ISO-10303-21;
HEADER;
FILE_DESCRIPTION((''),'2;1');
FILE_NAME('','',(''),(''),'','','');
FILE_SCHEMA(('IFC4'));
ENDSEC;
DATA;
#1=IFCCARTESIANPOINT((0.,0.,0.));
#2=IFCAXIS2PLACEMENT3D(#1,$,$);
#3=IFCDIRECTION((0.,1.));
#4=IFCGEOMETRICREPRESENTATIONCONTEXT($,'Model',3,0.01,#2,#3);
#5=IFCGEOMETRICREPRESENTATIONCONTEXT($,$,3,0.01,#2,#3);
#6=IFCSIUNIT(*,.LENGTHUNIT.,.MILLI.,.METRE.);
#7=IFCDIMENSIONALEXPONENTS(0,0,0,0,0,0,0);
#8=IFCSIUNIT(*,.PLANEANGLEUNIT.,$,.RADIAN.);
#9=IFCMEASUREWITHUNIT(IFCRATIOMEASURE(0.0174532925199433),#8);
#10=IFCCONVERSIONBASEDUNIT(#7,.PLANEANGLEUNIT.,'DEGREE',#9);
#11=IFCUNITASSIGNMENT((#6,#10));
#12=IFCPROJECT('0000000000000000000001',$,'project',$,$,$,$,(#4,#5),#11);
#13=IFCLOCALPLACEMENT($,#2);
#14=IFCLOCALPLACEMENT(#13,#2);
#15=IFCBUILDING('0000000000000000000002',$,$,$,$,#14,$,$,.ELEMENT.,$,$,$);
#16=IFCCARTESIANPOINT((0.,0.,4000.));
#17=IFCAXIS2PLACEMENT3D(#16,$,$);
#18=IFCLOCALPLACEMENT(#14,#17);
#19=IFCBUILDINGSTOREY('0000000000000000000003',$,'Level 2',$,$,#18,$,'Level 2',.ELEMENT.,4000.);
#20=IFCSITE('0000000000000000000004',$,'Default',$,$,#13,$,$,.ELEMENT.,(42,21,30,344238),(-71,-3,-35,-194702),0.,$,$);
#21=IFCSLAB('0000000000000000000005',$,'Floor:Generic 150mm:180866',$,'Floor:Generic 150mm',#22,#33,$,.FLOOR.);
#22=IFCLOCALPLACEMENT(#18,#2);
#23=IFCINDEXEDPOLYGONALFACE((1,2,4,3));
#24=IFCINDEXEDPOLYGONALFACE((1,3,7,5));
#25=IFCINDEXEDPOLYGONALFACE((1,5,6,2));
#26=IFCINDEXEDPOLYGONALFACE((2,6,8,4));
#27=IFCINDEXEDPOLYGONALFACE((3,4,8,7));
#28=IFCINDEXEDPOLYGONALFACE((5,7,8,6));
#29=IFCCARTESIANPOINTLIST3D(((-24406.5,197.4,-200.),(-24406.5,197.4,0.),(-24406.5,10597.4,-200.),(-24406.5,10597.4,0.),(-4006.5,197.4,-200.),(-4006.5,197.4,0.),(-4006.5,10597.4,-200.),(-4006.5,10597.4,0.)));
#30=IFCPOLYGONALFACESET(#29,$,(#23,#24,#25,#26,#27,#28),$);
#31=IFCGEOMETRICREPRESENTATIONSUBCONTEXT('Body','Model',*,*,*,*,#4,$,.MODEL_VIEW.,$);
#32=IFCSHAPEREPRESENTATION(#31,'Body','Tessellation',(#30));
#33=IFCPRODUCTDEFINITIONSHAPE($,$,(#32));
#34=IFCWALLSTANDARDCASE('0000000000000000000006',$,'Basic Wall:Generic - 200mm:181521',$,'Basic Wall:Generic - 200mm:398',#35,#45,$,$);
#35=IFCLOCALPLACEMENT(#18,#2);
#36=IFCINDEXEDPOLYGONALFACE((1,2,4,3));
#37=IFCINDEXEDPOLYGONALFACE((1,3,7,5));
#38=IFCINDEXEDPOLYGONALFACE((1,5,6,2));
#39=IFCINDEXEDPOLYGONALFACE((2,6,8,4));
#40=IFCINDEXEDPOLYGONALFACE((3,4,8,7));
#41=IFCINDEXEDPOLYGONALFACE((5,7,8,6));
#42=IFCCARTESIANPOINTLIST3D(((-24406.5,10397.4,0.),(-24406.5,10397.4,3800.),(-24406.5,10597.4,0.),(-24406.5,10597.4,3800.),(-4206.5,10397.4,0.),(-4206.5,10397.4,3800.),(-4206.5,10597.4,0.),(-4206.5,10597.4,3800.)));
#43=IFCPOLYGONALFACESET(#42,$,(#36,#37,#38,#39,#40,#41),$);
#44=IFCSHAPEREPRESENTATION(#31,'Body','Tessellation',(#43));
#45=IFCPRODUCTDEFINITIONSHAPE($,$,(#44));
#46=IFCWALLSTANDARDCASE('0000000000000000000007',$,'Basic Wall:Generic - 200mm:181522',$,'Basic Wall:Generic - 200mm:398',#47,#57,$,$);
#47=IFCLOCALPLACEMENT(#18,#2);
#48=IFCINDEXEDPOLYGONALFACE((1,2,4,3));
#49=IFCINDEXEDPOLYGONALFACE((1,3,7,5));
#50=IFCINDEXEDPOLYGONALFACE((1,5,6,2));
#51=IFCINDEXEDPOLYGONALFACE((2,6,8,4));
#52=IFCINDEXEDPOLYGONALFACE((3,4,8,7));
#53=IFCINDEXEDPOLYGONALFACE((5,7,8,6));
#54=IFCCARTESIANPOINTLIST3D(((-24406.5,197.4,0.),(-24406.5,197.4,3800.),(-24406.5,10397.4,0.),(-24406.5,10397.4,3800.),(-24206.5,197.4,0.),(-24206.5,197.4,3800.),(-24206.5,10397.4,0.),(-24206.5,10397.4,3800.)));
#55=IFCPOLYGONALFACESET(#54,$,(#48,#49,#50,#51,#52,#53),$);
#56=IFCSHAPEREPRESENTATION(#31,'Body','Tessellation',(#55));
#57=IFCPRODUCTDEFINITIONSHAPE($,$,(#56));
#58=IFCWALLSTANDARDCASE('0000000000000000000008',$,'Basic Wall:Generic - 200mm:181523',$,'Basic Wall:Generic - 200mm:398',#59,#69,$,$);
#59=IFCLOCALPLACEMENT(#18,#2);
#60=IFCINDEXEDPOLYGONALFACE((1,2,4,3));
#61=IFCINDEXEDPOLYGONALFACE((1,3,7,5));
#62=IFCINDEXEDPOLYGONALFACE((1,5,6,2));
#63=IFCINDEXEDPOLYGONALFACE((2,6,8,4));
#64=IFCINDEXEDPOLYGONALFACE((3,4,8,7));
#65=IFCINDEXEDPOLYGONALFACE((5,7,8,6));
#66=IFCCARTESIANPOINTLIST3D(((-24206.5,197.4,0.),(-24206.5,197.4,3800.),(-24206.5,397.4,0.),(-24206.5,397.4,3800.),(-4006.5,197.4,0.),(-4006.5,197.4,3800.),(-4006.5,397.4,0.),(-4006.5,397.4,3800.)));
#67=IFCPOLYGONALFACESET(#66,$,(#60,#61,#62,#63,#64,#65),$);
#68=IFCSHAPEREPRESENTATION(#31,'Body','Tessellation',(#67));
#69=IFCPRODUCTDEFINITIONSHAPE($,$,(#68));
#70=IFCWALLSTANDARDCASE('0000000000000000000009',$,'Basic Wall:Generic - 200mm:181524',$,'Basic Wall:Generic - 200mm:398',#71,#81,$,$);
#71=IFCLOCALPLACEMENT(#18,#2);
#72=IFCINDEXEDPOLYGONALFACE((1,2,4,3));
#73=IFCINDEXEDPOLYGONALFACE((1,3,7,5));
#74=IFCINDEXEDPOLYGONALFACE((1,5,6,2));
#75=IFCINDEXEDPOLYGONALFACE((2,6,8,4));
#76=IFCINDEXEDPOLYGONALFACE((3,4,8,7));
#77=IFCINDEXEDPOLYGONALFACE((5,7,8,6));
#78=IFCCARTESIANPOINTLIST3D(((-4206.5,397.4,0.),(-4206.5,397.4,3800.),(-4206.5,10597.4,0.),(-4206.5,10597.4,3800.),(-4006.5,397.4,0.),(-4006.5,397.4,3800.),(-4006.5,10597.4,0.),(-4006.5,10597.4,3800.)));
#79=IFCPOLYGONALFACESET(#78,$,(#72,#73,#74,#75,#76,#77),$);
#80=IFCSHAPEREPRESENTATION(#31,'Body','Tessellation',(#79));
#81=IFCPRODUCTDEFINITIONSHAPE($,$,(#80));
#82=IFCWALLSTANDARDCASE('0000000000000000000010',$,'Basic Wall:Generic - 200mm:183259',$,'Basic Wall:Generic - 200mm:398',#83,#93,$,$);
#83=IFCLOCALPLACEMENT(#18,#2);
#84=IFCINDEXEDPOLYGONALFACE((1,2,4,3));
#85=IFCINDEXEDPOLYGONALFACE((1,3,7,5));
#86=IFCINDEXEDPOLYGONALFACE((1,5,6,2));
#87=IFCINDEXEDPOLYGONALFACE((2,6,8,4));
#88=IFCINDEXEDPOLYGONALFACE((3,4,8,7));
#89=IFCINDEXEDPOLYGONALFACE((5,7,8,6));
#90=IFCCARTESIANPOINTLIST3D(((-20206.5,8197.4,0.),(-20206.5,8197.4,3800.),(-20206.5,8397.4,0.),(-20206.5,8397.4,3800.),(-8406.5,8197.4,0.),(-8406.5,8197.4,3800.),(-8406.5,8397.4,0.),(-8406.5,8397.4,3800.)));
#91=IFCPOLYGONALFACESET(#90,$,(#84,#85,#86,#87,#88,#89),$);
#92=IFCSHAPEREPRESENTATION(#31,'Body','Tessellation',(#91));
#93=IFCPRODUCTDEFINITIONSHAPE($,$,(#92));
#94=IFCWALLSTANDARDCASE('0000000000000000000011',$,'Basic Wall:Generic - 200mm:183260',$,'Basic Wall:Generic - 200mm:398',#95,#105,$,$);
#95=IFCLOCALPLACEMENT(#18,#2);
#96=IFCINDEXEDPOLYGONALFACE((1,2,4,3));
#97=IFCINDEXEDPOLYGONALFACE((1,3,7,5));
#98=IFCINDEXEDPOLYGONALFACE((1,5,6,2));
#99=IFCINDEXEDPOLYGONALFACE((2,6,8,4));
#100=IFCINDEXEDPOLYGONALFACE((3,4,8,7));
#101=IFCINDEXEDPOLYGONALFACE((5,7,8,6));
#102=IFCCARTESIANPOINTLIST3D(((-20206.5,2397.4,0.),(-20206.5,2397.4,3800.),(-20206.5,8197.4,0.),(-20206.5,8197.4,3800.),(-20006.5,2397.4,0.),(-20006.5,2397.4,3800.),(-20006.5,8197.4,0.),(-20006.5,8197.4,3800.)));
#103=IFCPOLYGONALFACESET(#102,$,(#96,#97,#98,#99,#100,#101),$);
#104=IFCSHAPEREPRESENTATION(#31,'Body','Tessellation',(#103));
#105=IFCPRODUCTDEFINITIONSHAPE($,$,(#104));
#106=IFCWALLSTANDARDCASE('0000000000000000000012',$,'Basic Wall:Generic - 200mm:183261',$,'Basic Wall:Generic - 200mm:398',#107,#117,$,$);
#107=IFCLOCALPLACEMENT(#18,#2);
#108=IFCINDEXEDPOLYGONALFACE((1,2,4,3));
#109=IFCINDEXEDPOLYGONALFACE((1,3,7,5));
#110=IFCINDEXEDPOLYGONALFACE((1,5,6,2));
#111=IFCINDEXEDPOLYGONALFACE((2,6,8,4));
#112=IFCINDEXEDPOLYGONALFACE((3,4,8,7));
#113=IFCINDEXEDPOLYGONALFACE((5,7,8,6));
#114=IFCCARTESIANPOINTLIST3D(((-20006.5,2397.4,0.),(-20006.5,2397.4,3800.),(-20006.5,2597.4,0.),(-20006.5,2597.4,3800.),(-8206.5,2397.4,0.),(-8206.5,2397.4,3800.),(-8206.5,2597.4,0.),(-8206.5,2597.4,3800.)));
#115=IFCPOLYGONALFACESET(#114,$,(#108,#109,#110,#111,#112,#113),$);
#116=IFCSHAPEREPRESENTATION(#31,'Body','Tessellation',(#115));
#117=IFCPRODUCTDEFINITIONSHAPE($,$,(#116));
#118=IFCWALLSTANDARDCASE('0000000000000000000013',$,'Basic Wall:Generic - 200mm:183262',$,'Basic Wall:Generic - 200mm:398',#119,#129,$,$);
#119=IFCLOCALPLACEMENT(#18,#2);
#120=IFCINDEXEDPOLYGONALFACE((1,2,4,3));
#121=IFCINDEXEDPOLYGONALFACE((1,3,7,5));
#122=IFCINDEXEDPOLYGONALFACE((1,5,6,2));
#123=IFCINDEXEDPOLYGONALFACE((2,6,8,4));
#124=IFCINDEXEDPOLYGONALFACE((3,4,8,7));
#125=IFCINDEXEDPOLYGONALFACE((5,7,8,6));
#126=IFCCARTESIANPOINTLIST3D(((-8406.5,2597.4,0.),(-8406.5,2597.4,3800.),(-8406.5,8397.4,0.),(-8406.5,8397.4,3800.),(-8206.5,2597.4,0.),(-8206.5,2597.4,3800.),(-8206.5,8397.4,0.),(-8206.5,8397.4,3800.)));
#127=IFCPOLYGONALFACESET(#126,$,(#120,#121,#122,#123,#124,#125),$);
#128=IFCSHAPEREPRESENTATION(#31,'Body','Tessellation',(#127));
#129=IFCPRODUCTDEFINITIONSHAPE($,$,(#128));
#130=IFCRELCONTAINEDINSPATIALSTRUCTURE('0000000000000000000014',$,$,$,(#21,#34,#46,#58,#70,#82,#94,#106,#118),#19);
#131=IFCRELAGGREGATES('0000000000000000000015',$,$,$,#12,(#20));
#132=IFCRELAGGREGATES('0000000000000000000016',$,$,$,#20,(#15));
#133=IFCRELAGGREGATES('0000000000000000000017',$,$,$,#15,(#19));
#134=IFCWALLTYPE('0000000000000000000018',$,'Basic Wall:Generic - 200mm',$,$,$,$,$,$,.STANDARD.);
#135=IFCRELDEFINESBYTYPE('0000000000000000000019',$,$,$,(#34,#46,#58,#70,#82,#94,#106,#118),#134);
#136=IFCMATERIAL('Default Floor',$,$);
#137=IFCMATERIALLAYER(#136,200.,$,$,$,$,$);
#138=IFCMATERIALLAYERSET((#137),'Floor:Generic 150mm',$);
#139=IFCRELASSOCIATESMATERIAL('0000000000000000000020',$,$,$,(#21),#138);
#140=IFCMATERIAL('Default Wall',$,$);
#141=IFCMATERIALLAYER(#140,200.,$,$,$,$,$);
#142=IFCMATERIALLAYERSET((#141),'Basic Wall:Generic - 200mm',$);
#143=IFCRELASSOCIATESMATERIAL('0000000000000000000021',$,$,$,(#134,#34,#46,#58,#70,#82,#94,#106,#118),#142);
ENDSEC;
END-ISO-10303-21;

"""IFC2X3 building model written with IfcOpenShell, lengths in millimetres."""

from ifc_helpers import new_model, entity, si_unit, converted_unit, direction, frame, frame_2d, origin, origin_2d_with_axis, place, context, subcontext, project, spatial, rectangle, extrude, material, layer, layer_set, layer_usage, type_object, element, save


model = new_model("IFC2X3")

# Units and contexts
model_context = context("Model", 3, precision=0.01, world=origin(), true_north=direction((0.0, 1.0)))
context_of_model = context(None, 3, precision=0.01, world=origin(), true_north=direction((0.0, 1.0)))
body_context = subcontext(model_context, "Body", "Model", "MODEL_VIEW")
ifc_project = project(units=[si_unit("LENGTHUNIT", "METRE", prefix="MILLI"), converted_unit("PLANEANGLEUNIT", "DEGREE", entity("IfcRatioMeasure", 0.0174532925199433), si_unit("PLANEANGLEUNIT", "RADIAN"), dimensions=[0, 0, 0, 0, 0, 0, 0])], contexts=[model_context, context_of_model])

# Site, building, storey
site_placement = place(None, origin())
site = spatial("IfcSite", under=ifc_project, at=site_placement, Name="Default", CompositionType="ELEMENT", RefLatitude=(42, 21, 30, 344238), RefLongitude=(-71, -3, -35, -194702), RefElevation=0.0)
building_placement = place(site_placement, origin())
building = spatial("IfcBuilding", under=site, at=building_placement, CompositionType="ELEMENT")
storey_placement = place(building_placement, frame((0.0, 0.0, 4000.0)))
storey = spatial("IfcBuildingStorey", under=building, at=storey_placement, Name="Level 2", LongName="Level 2", CompositionType="ELEMENT", Elevation=4000.0)

# Slab
ifc_material_1 = material(Name="Default Floor")
ifc_layer_1 = layer(ifc_material_1, 200.0)
ifc_layer_set_1 = layer_set([ifc_layer_1], Name="Floor:Generic 150mm")
ifc_layer_usage_1 = layer_usage(ifc_layer_set_1, "AXIS3", "POSITIVE", 0.0)
slab_placement = place(storey_placement, origin())
element("IfcSlab", 1, at=slab_placement, inside=storey, material=ifc_layer_usage_1, Name="Floor:Generic 150mm:180866", ObjectType="Floor:Generic 150mm", PredefinedType="FLOOR", context=body_context, shape_type="SweptSolid", body=[
    extrude(rectangle(XDim=10400.0, YDim=20400.0, at=origin_2d_with_axis()), frame((-14206.5, 5397.4, 0.0), z_axis=(0.0, 0.0, -1.0), x_axis=(0.0, 1.0, 0.0)), (0.0, 0.0, 1.0), 200.0),
])

# Walls
ifc_material_2 = material(Name="Default Wall")
ifc_layer_2 = layer(ifc_material_2, 200.0)
ifc_layer_set_2 = layer_set([ifc_layer_2], Name="Basic Wall:Generic - 200mm")
ifc_layer_usage_2 = layer_usage(ifc_layer_set_2, "AXIS2", "NEGATIVE", 100.0)
wall_type = type_object("IfcWallType", Name="Basic Wall:Generic - 200mm", PredefinedType="STANDARD", material=ifc_layer_set_2)
wall_1_placement = place(storey_placement, frame((-24406.5, 10497.4, 0.0)))
element("IfcWallStandardCase", 2, at=wall_1_placement, inside=storey, type_object=wall_type, material=ifc_layer_usage_2, Name="Basic Wall:Generic - 200mm:181521", ObjectType="Basic Wall:Generic - 200mm:398", context=body_context, shape_type="SweptSolid", body=[
    extrude(rectangle(XDim=20200.0, YDim=200.0, at=frame_2d((10100.0, 0.0), x_axis=(-1.0, 0.0))), origin(), (0.0, 0.0, 1.0), 3800.0),
])
ifc_layer_usage_3 = layer_usage(ifc_layer_set_2, "AXIS2", "NEGATIVE", 100.0)
wall_2_placement = place(storey_placement, frame((-24306.5, 197.4, 0.0), z_axis=(0.0, 0.0, 1.0), x_axis=(0.0, 1.0, 0.0)))
element("IfcWallStandardCase", 3, at=wall_2_placement, inside=storey, type_object=wall_type, material=ifc_layer_usage_3, Name="Basic Wall:Generic - 200mm:181522", ObjectType="Basic Wall:Generic - 200mm:398", context=body_context, shape_type="SweptSolid", body=[
    extrude(rectangle(XDim=10200.0, YDim=200.0, at=frame_2d((5100.0, 0.0), x_axis=(-1.0, 0.0))), origin(), (0.0, 0.0, 1.0), 3800.0),
])
ifc_layer_usage_4 = layer_usage(ifc_layer_set_2, "AXIS2", "NEGATIVE", 100.0)
wall_3_placement = place(storey_placement, frame((-4006.5, 297.4, 0.0), z_axis=(0.0, 0.0, 1.0), x_axis=(-1.0, 0.0, 0.0)))
element("IfcWallStandardCase", 4, at=wall_3_placement, inside=storey, type_object=wall_type, material=ifc_layer_usage_4, Name="Basic Wall:Generic - 200mm:181523", ObjectType="Basic Wall:Generic - 200mm:398", context=body_context, shape_type="SweptSolid", body=[
    extrude(rectangle(XDim=20200.0, YDim=200.0, at=frame_2d((10100.0, 0.0), x_axis=(-1.0, 0.0))), origin(), (0.0, 0.0, 1.0), 3800.0),
])
ifc_layer_usage_5 = layer_usage(ifc_layer_set_2, "AXIS2", "NEGATIVE", 100.0)
wall_4_placement = place(storey_placement, frame((-4106.5, 10597.4, 0.0), z_axis=(0.0, 0.0, 1.0), x_axis=(0.0, -1.0, 0.0)))
element("IfcWallStandardCase", 5, at=wall_4_placement, inside=storey, type_object=wall_type, material=ifc_layer_usage_5, Name="Basic Wall:Generic - 200mm:181524", ObjectType="Basic Wall:Generic - 200mm:398", context=body_context, shape_type="SweptSolid", body=[
    extrude(rectangle(XDim=10200.0, YDim=200.0, at=frame_2d((5100.0, 0.0), x_axis=(-1.0, 0.0))), origin(), (0.0, 0.0, 1.0), 3800.0),
])
ifc_layer_usage_6 = layer_usage(ifc_layer_set_2, "AXIS2", "NEGATIVE", 100.0)
wall_5_placement = place(storey_placement, frame((-20206.5, 8297.4, 0.0)))
element("IfcWallStandardCase", 6, at=wall_5_placement, inside=storey, type_object=wall_type, material=ifc_layer_usage_6, Name="Basic Wall:Generic - 200mm:183259", ObjectType="Basic Wall:Generic - 200mm:398", context=body_context, shape_type="SweptSolid", body=[
    extrude(rectangle(XDim=11800.0, YDim=200.0, at=frame_2d((5900.0, 0.0), x_axis=(-1.0, 0.0))), origin(), (0.0, 0.0, 1.0), 3800.0),
])
ifc_layer_usage_7 = layer_usage(ifc_layer_set_2, "AXIS2", "NEGATIVE", 100.0)
wall_6_placement = place(storey_placement, frame((-20106.5, 2397.4, 0.0), z_axis=(0.0, 0.0, 1.0), x_axis=(0.0, 1.0, 0.0)))
element("IfcWallStandardCase", 7, at=wall_6_placement, inside=storey, type_object=wall_type, material=ifc_layer_usage_7, Name="Basic Wall:Generic - 200mm:183260", ObjectType="Basic Wall:Generic - 200mm:398", context=body_context, shape_type="SweptSolid", body=[
    extrude(rectangle(XDim=5800.0, YDim=200.0, at=frame_2d((2900.0, 0.0), x_axis=(-1.0, 0.0))), origin(), (0.0, 0.0, 1.0), 3800.0),
])
ifc_layer_usage_8 = layer_usage(ifc_layer_set_2, "AXIS2", "NEGATIVE", 100.0)
wall_7_placement = place(storey_placement, frame((-8206.5, 2497.4, 0.0), z_axis=(0.0, 0.0, 1.0), x_axis=(-1.0, 0.0, 0.0)))
element("IfcWallStandardCase", 8, at=wall_7_placement, inside=storey, type_object=wall_type, material=ifc_layer_usage_8, Name="Basic Wall:Generic - 200mm:183261", ObjectType="Basic Wall:Generic - 200mm:398", context=body_context, shape_type="SweptSolid", body=[
    extrude(rectangle(XDim=11800.0, YDim=200.0, at=frame_2d((5900.0, 0.0), x_axis=(-1.0, 0.0))), origin(), (0.0, 0.0, 1.0), 3800.0),
])
ifc_layer_usage_9 = layer_usage(ifc_layer_set_2, "AXIS2", "NEGATIVE", 100.0)
wall_8_placement = place(storey_placement, frame((-8306.5, 8397.4, 0.0), z_axis=(0.0, 0.0, 1.0), x_axis=(0.0, -1.0, 0.0)))
element("IfcWallStandardCase", 9, at=wall_8_placement, inside=storey, type_object=wall_type, material=ifc_layer_usage_9, Name="Basic Wall:Generic - 200mm:183262", ObjectType="Basic Wall:Generic - 200mm:398", context=body_context, shape_type="SweptSolid", body=[
    extrude(rectangle(XDim=5800.0, YDim=200.0, at=frame_2d((2900.0, 0.0), x_axis=(-1.0, 0.0))), origin(), (0.0, 0.0, 1.0), 3800.0),
])

save(model, "model.ifc")
